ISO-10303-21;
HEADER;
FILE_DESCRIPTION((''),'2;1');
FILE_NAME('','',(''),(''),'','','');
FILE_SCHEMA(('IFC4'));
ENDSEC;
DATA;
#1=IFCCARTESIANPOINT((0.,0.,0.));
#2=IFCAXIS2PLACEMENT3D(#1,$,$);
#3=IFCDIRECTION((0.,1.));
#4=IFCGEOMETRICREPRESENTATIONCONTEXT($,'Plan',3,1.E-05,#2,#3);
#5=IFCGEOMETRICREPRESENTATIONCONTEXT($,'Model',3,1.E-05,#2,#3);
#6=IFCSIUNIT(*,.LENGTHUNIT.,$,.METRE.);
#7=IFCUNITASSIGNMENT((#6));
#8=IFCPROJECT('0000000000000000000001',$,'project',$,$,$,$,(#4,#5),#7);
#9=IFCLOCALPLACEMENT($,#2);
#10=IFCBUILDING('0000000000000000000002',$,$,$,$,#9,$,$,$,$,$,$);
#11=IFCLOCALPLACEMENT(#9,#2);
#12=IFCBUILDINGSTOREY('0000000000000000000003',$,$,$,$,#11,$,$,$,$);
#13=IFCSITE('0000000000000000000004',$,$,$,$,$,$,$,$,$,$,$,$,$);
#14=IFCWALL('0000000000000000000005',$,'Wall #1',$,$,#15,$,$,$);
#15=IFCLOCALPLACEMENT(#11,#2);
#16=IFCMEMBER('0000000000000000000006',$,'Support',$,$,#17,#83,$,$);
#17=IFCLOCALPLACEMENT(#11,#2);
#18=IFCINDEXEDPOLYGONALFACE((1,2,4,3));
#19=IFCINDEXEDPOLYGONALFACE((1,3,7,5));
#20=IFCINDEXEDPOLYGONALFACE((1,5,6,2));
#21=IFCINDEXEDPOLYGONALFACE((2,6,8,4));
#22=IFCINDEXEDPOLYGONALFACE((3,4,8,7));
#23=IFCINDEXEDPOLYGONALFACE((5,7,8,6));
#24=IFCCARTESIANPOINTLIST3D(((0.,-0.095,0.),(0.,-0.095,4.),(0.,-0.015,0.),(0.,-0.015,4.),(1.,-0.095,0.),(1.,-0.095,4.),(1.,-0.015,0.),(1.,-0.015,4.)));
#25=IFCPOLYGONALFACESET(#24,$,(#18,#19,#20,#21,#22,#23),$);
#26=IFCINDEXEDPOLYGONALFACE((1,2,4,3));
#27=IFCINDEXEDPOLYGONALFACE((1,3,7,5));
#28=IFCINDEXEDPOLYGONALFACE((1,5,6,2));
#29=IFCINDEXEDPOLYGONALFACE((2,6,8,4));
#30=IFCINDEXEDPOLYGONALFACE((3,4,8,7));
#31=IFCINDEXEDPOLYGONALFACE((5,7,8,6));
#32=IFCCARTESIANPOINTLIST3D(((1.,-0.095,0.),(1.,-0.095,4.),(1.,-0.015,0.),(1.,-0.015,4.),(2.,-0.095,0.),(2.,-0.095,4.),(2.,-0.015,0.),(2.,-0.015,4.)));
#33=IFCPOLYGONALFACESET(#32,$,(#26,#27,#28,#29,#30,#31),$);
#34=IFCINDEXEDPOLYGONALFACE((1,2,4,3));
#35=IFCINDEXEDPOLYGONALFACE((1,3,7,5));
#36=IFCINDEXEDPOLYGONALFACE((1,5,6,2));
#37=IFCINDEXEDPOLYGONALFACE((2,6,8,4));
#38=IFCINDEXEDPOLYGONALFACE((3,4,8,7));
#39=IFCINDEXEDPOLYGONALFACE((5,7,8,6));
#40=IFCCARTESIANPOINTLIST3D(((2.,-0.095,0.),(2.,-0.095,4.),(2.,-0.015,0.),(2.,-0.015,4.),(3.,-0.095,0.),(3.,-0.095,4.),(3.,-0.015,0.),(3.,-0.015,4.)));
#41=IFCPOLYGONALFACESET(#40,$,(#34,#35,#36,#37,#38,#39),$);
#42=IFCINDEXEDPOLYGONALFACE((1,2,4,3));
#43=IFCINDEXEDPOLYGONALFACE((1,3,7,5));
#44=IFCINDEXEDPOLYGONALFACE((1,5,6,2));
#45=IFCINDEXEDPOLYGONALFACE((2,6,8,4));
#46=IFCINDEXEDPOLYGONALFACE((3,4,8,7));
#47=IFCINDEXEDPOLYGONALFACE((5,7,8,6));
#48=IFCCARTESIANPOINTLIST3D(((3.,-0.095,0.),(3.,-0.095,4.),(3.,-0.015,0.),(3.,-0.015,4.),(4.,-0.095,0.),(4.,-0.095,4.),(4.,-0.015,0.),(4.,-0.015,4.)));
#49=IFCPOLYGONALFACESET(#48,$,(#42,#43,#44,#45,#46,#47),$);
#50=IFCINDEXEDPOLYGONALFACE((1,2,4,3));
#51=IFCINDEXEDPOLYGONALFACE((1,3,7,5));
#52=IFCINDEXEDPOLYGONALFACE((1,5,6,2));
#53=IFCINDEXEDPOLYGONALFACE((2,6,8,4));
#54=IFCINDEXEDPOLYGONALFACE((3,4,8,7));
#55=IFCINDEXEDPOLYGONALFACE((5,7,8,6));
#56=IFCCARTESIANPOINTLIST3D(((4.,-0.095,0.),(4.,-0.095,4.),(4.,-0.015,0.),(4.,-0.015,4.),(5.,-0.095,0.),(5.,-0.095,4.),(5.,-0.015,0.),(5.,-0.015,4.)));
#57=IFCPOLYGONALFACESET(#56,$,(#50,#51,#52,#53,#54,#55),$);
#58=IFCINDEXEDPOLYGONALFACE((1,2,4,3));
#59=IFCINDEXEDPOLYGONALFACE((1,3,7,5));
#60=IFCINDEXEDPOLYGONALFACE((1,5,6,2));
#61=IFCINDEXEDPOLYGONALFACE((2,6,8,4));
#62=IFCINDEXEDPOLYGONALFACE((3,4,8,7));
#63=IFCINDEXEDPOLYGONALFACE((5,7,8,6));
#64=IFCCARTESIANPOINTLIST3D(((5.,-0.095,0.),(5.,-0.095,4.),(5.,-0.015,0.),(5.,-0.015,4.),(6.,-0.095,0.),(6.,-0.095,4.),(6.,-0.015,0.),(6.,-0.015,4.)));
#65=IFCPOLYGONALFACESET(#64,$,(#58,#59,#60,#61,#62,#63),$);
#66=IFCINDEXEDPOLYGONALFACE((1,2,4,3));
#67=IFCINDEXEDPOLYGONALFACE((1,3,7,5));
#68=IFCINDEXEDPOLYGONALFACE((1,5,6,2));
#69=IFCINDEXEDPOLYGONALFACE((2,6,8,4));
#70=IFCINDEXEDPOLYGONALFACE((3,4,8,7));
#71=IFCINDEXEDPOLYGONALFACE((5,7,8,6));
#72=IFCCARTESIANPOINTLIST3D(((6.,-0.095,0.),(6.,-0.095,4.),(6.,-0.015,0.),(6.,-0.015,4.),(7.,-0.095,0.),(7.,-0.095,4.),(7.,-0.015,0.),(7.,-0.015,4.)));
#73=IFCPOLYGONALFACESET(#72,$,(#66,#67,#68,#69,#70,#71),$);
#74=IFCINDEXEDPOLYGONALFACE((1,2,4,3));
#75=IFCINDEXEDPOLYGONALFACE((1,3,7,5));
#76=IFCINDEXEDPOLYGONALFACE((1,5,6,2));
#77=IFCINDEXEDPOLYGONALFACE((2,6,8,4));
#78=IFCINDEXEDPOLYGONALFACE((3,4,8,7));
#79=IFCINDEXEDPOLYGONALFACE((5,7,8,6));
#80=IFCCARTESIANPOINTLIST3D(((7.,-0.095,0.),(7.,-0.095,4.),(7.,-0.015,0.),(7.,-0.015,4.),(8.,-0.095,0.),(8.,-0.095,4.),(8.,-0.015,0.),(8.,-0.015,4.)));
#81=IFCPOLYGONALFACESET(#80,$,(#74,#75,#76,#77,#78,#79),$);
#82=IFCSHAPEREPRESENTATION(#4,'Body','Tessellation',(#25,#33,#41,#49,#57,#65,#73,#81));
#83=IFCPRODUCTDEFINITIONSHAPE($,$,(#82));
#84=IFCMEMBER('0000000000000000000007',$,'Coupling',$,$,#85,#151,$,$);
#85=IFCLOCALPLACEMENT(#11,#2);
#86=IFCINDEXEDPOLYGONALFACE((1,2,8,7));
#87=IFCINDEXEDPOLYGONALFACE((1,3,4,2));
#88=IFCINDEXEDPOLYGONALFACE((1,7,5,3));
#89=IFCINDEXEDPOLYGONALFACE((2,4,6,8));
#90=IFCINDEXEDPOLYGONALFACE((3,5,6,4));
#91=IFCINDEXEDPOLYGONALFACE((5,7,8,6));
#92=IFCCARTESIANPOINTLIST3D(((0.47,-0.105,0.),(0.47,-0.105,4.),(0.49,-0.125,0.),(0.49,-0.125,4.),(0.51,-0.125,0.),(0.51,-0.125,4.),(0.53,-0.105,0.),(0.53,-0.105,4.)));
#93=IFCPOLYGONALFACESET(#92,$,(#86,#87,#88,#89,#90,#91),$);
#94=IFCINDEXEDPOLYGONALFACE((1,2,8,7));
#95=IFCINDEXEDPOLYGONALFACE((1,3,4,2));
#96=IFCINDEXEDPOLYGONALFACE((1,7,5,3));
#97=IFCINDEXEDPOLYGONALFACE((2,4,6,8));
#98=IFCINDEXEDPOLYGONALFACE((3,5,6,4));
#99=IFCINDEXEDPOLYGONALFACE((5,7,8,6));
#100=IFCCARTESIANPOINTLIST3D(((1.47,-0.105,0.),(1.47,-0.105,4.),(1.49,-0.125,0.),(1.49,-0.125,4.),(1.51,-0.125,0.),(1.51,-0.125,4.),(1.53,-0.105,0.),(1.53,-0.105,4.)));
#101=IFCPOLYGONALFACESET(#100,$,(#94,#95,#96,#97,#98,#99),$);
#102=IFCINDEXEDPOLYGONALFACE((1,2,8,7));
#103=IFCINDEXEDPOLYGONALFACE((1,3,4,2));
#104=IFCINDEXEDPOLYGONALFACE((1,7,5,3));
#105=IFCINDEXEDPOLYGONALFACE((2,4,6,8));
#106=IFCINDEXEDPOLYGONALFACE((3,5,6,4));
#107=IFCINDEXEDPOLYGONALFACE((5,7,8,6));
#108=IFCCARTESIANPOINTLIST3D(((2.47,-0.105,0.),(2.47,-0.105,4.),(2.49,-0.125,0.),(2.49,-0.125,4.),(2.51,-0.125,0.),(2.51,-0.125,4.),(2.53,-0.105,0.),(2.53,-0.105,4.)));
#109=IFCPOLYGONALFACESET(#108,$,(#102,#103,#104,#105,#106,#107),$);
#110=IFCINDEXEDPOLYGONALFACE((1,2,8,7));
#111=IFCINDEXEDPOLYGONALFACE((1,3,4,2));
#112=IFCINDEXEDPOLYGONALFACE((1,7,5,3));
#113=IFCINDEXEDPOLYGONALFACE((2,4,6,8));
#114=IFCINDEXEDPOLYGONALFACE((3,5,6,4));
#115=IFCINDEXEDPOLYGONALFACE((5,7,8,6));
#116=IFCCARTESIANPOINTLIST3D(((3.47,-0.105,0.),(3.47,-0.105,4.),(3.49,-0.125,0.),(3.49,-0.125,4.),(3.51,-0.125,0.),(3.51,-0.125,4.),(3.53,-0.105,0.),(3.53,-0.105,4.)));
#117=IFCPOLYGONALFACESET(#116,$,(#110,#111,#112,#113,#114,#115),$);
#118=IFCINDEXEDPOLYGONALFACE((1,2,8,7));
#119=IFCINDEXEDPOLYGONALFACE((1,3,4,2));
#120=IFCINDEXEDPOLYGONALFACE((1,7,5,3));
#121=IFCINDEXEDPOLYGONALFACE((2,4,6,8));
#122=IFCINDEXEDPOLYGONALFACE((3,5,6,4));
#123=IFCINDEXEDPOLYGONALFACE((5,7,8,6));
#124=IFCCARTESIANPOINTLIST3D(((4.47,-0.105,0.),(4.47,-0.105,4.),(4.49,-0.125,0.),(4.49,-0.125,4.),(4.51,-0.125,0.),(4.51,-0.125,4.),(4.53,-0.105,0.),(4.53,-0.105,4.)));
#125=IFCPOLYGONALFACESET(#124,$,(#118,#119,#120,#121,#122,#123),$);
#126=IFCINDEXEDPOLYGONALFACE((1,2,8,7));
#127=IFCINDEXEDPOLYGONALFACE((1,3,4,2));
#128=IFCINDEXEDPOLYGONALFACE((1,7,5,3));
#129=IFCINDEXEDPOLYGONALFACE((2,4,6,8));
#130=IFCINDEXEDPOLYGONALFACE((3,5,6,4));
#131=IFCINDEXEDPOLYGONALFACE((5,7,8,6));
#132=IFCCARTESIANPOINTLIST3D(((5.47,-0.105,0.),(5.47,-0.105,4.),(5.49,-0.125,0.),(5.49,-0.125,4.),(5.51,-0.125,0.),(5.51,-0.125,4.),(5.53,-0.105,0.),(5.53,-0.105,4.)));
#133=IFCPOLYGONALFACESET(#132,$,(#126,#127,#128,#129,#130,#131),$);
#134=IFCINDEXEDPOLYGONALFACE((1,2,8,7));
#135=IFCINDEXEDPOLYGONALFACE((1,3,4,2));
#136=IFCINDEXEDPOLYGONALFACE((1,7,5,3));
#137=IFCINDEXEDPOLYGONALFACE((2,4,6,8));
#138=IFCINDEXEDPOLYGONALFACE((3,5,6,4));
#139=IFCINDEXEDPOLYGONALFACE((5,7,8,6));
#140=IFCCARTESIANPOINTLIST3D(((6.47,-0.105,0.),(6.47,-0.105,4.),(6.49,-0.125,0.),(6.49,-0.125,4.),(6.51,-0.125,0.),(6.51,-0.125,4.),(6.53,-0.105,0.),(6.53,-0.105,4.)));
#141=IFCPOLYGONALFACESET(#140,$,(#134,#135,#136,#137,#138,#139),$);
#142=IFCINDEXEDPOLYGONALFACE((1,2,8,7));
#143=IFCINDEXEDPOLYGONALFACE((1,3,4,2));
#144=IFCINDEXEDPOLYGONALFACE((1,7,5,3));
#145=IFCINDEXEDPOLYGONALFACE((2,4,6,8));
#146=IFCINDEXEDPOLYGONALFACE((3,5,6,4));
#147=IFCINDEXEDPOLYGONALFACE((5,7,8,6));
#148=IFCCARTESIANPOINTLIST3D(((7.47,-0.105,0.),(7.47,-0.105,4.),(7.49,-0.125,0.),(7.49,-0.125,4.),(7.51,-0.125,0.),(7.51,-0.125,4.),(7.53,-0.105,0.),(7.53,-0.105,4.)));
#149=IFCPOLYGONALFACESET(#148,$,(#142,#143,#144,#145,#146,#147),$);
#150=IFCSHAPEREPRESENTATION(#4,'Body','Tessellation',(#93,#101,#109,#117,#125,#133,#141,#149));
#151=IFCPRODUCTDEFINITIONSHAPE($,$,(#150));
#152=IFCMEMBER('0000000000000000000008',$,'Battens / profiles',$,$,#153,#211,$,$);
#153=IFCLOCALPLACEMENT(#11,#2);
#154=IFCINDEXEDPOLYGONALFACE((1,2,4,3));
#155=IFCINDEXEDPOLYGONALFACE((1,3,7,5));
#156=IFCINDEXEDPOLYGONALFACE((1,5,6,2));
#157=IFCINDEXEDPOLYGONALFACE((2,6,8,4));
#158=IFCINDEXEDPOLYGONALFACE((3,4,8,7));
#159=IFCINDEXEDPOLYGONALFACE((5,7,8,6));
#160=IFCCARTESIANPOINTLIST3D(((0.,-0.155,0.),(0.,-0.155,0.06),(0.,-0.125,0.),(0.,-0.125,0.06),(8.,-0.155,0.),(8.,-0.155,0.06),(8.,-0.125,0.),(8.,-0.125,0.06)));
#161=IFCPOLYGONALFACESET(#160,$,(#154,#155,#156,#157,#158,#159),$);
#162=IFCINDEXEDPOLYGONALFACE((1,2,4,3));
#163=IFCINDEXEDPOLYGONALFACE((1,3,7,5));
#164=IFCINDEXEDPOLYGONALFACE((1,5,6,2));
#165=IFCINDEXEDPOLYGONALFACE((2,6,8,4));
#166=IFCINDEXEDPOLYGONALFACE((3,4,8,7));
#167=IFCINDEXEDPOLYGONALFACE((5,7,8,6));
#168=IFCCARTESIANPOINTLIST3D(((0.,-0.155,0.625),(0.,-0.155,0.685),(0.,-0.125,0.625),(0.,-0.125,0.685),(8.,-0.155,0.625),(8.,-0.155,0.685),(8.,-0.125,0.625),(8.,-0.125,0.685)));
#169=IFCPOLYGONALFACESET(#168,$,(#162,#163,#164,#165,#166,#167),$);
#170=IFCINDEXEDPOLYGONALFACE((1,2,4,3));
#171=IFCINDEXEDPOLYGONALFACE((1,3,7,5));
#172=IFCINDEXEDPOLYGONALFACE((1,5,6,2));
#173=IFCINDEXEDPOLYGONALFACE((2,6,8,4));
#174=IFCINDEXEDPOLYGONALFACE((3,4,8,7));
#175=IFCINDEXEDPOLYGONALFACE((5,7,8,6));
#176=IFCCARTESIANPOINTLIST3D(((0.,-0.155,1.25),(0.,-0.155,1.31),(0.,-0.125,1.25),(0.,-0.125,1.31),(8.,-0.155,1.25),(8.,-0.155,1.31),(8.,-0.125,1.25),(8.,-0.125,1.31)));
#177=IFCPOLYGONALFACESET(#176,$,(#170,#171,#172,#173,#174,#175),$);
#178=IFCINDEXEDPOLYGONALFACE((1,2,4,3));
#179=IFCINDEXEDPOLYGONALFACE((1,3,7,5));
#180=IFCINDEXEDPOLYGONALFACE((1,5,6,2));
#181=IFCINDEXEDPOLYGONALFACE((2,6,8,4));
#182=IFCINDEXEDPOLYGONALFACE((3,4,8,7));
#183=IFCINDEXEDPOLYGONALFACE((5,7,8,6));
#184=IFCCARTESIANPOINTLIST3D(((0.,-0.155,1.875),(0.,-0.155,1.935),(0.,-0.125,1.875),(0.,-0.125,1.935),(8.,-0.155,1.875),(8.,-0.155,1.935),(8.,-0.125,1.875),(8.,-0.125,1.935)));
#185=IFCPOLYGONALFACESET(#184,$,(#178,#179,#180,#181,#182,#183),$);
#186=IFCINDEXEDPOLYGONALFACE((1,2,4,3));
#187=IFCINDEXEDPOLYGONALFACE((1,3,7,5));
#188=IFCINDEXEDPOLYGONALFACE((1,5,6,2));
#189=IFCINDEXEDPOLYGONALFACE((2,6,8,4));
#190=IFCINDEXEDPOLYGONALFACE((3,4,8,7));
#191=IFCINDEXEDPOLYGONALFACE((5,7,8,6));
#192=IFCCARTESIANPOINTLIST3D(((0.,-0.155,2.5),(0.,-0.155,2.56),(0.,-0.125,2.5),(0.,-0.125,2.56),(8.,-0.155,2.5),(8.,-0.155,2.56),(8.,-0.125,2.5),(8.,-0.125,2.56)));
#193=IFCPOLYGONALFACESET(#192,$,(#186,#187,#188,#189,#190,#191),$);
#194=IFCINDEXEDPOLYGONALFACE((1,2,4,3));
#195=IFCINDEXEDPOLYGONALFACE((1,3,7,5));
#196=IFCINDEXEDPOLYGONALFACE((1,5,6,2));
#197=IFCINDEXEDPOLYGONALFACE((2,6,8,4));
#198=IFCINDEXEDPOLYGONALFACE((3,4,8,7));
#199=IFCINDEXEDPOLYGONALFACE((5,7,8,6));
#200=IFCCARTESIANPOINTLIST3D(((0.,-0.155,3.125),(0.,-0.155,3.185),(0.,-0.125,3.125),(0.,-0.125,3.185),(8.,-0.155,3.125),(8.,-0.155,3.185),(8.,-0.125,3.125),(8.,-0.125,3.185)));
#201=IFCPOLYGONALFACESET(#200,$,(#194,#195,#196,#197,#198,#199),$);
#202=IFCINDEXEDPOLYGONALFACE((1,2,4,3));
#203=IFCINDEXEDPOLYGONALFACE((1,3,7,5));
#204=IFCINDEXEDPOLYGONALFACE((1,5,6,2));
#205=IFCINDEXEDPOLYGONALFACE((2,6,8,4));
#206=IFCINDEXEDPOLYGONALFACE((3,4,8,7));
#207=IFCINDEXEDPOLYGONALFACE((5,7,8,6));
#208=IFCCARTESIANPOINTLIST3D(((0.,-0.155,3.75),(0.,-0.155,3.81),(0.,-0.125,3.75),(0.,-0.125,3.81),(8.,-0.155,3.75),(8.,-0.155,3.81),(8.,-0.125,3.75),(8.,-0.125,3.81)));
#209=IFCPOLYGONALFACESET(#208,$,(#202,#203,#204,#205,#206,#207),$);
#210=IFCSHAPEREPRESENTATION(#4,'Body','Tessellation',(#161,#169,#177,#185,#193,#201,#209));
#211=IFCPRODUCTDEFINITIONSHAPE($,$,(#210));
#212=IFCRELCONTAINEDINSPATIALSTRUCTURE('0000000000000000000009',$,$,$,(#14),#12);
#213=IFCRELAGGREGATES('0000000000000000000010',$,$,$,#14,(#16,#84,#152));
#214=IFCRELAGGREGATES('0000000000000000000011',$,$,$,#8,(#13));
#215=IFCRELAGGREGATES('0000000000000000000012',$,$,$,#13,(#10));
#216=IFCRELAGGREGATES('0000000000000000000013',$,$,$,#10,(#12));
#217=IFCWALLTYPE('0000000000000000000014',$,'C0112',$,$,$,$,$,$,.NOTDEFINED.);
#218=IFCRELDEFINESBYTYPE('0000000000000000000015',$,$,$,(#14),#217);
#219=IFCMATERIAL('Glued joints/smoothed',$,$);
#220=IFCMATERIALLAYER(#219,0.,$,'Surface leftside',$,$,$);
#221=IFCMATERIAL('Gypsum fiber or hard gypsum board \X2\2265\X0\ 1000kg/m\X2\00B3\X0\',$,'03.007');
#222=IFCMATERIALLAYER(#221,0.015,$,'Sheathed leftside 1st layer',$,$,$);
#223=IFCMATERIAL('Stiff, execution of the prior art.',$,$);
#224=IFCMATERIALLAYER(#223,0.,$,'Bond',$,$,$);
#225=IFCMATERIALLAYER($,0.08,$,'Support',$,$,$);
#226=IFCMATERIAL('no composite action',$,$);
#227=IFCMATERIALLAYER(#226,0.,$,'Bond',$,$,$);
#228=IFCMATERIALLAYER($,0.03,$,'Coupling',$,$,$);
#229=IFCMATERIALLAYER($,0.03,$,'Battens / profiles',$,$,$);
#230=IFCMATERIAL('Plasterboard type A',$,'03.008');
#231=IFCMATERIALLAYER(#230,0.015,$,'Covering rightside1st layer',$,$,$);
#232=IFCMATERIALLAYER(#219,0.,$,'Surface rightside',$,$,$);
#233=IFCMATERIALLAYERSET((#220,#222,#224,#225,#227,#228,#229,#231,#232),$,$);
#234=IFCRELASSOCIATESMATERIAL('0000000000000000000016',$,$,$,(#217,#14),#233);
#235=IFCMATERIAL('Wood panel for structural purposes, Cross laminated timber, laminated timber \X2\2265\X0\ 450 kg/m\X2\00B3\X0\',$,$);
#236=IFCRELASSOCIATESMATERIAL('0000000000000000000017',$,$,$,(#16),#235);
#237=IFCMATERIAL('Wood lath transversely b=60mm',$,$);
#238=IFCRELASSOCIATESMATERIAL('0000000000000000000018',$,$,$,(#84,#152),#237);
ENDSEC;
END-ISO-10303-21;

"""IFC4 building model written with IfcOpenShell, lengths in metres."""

from ifc_helpers import new_model, si_unit, direction, frame, frame_2d, origin, place, context, project, spatial, polyline, rectangle, outline, extrude, material, layer, layer_set, type_object, element, aggregate, save


model = new_model("IFC4")

# Units and contexts
plan_context = context("Plan", 3, precision=1e-05, world=origin(), true_north=direction((0.0, 1.0)))
model_context = context("Model", 3, precision=1e-05, world=origin(), true_north=direction((0.0, 1.0)))
ifc_project = project(units=[si_unit("LENGTHUNIT", "METRE")], contexts=[plan_context, model_context])

# Site, building, storey
site = spatial("IfcSite", under=ifc_project)
building_placement = place(None, origin())
building = spatial("IfcBuilding", under=site, at=building_placement)
storey_placement = place(building_placement, origin())
storey = spatial("IfcBuildingStorey", under=building, at=storey_placement)

# Wall, members
ifc_material_1 = material(Name="Glued joints/smoothed")
ifc_layer_1 = layer(ifc_material_1, 0.0, Name="Surface leftside")
ifc_material_2 = material(Name="Gypsum fiber or hard gypsum board ≥ 1000kg/m³", Category="03.007")
ifc_layer_2 = layer(ifc_material_2, 0.015, Name="Sheathed leftside 1st layer")
ifc_material_3 = material(Name="Stiff, execution of the prior art.")
ifc_layer_3 = layer(ifc_material_3, 0.0, Name="Bond")
ifc_layer_4 = layer(None, 0.08, Name="Support")
ifc_material_4 = material(Name="no composite action")
ifc_layer_5 = layer(ifc_material_4, 0.0, Name="Bond")
ifc_layer_6 = layer(None, 0.03, Name="Coupling")
ifc_layer_7 = layer(None, 0.03, Name="Battens / profiles")
ifc_material_5 = material(Name="Plasterboard type A", Category="03.008")
ifc_layer_8 = layer(ifc_material_5, 0.015, Name="Covering rightside1st layer")
ifc_layer_9 = layer(ifc_material_1, 0.0, Name="Surface rightside")
ifc_layer_set = layer_set([ifc_layer_1, ifc_layer_2, ifc_layer_3, ifc_layer_4, ifc_layer_5, ifc_layer_6, ifc_layer_7, ifc_layer_8, ifc_layer_9])
wall_type = type_object("IfcWallType", Name="C0112", PredefinedType="NOTDEFINED", material=ifc_layer_set)
wall_placement = place(None, frame((0.0, 0.0, 0.0), z_axis=(0.0, -1.0, 0.0), x_axis=(1.0, 0.0, 0.0)))
wall = element("IfcWall", 1, at=wall_placement, inside=storey, type_object=wall_type, material=ifc_layer_set, Name="Wall #1")
ifc_material_6 = material(Name="Wood panel for structural purposes, Cross laminated timber, laminated timber ≥ 450 kg/m³")
member_1_placement = place(wall_placement, origin())
member_1 = element("IfcMember", 2, at=member_1_placement, material=ifc_material_6, Name="Support", context=plan_context, shape_type="SweptSolid", body=[
    extrude(rectangle(XDim=1.0, YDim=0.08, at=frame_2d((0.5, 0.04), x_axis=(1.0, 0.0))), frame((0.0, 4.0, 0.015), z_axis=(0.0, -1.0, 0.0), x_axis=(1.0, 0.0, 0.0)), (0.0, 0.0, 1.0), 4.0),
    extrude(rectangle(XDim=1.0, YDim=0.08, at=frame_2d((0.5, 0.04), x_axis=(1.0, 0.0))), frame((1.0, 4.0, 0.015), z_axis=(0.0, -1.0, 0.0), x_axis=(1.0, 0.0, 0.0)), (0.0, 0.0, 1.0), 4.0),
    extrude(rectangle(XDim=1.0, YDim=0.08, at=frame_2d((0.5, 0.04), x_axis=(1.0, 0.0))), frame((2.0, 4.0, 0.015), z_axis=(0.0, -1.0, 0.0), x_axis=(1.0, 0.0, 0.0)), (0.0, 0.0, 1.0), 4.0),
    extrude(rectangle(XDim=1.0, YDim=0.08, at=frame_2d((0.5, 0.04), x_axis=(1.0, 0.0))), frame((3.0, 4.0, 0.015), z_axis=(0.0, -1.0, 0.0), x_axis=(1.0, 0.0, 0.0)), (0.0, 0.0, 1.0), 4.0),
    extrude(rectangle(XDim=1.0, YDim=0.08, at=frame_2d((0.5, 0.04), x_axis=(1.0, 0.0))), frame((4.0, 4.0, 0.015), z_axis=(0.0, -1.0, 0.0), x_axis=(1.0, 0.0, 0.0)), (0.0, 0.0, 1.0), 4.0),
    extrude(rectangle(XDim=1.0, YDim=0.08, at=frame_2d((0.5, 0.04), x_axis=(1.0, 0.0))), frame((5.0, 4.0, 0.015), z_axis=(0.0, -1.0, 0.0), x_axis=(1.0, 0.0, 0.0)), (0.0, 0.0, 1.0), 4.0),
    extrude(rectangle(XDim=1.0, YDim=0.08, at=frame_2d((0.5, 0.04), x_axis=(1.0, 0.0))), frame((6.0, 4.0, 0.015), z_axis=(0.0, -1.0, 0.0), x_axis=(1.0, 0.0, 0.0)), (0.0, 0.0, 1.0), 4.0),
    extrude(rectangle(XDim=1.0, YDim=0.08, at=frame_2d((0.5, 0.04), x_axis=(1.0, 0.0))), frame((7.0, 4.0, 0.015), z_axis=(0.0, -1.0, 0.0), x_axis=(1.0, 0.0, 0.0)), (0.0, 0.0, 1.0), 4.0),
])
ifc_material_7 = material(Name="Wood lath transversely b=60mm")
member_2_placement = place(wall_placement, origin())
member_2 = element("IfcMember", 3, at=member_2_placement, material=ifc_material_7, Name="Coupling", context=plan_context, shape_type="SweptSolid", body=[
    extrude(outline(polyline([(0.0, 0.0), (0.06, 0.0), (0.04, 0.02), (0.02, 0.02), (0.0, 0.0)])), frame((0.47, 4.0, 0.105), z_axis=(0.0, -1.0, 0.0), x_axis=(1.0, 0.0, 0.0)), (0.0, 0.0, 1.0), 4.0),
    extrude(outline(polyline([(0.0, 0.0), (0.06, 0.0), (0.04, 0.02), (0.02, 0.02), (0.0, 0.0)])), frame((1.47, 4.0, 0.105), z_axis=(0.0, -1.0, 0.0), x_axis=(1.0, 0.0, 0.0)), (0.0, 0.0, 1.0), 4.0),
    extrude(outline(polyline([(0.0, 0.0), (0.06, 0.0), (0.04, 0.02), (0.02, 0.02), (0.0, 0.0)])), frame((2.47, 4.0, 0.105), z_axis=(0.0, -1.0, 0.0), x_axis=(1.0, 0.0, 0.0)), (0.0, 0.0, 1.0), 4.0),
    extrude(outline(polyline([(0.0, 0.0), (0.06, 0.0), (0.04, 0.02), (0.02, 0.02), (0.0, 0.0)])), frame((3.47, 4.0, 0.105), z_axis=(0.0, -1.0, 0.0), x_axis=(1.0, 0.0, 0.0)), (0.0, 0.0, 1.0), 4.0),
    extrude(outline(polyline([(0.0, 0.0), (0.06, 0.0), (0.04, 0.02), (0.02, 0.02), (0.0, 0.0)])), frame((4.47, 4.0, 0.105), z_axis=(0.0, -1.0, 0.0), x_axis=(1.0, 0.0, 0.0)), (0.0, 0.0, 1.0), 4.0),
    extrude(outline(polyline([(0.0, 0.0), (0.06, 0.0), (0.04, 0.02), (0.02, 0.02), (0.0, 0.0)])), frame((5.47, 4.0, 0.105), z_axis=(0.0, -1.0, 0.0), x_axis=(1.0, 0.0, 0.0)), (0.0, 0.0, 1.0), 4.0),
    extrude(outline(polyline([(0.0, 0.0), (0.06, 0.0), (0.04, 0.02), (0.02, 0.02), (0.0, 0.0)])), frame((6.47, 4.0, 0.105), z_axis=(0.0, -1.0, 0.0), x_axis=(1.0, 0.0, 0.0)), (0.0, 0.0, 1.0), 4.0),
    extrude(outline(polyline([(0.0, 0.0), (0.06, 0.0), (0.04, 0.02), (0.02, 0.02), (0.0, 0.0)])), frame((7.47, 4.0, 0.105), z_axis=(0.0, -1.0, 0.0), x_axis=(1.0, 0.0, 0.0)), (0.0, 0.0, 1.0), 4.0),
])
member_3_placement = place(wall_placement, origin())
member_3 = element("IfcMember", 4, at=member_3_placement, material=ifc_material_7, Name="Battens / profiles", context=plan_context, shape_type="SweptSolid", body=[
    extrude(rectangle(XDim=0.06, YDim=0.03, at=frame_2d((0.03, 0.015), x_axis=(1.0, 0.0))), frame((0.0, 0.0, 0.125), z_axis=(1.0, 0.0, 0.0), x_axis=(0.0, 1.0, 0.0)), (0.0, 0.0, 1.0), 8.0),
    extrude(rectangle(XDim=0.06, YDim=0.03, at=frame_2d((0.03, 0.015), x_axis=(1.0, 0.0))), frame((0.0, 0.625, 0.125), z_axis=(1.0, 0.0, 0.0), x_axis=(0.0, 1.0, 0.0)), (0.0, 0.0, 1.0), 8.0),
    extrude(rectangle(XDim=0.06, YDim=0.03, at=frame_2d((0.03, 0.015), x_axis=(1.0, 0.0))), frame((0.0, 1.25, 0.125), z_axis=(1.0, 0.0, 0.0), x_axis=(0.0, 1.0, 0.0)), (0.0, 0.0, 1.0), 8.0),
    extrude(rectangle(XDim=0.06, YDim=0.03, at=frame_2d((0.03, 0.015), x_axis=(1.0, 0.0))), frame((0.0, 1.875, 0.125), z_axis=(1.0, 0.0, 0.0), x_axis=(0.0, 1.0, 0.0)), (0.0, 0.0, 1.0), 8.0),
    extrude(rectangle(XDim=0.06, YDim=0.03, at=frame_2d((0.03, 0.015), x_axis=(1.0, 0.0))), frame((0.0, 2.5, 0.125), z_axis=(1.0, 0.0, 0.0), x_axis=(0.0, 1.0, 0.0)), (0.0, 0.0, 1.0), 8.0),
    extrude(rectangle(XDim=0.06, YDim=0.03, at=frame_2d((0.03, 0.015), x_axis=(1.0, 0.0))), frame((0.0, 3.125, 0.125), z_axis=(1.0, 0.0, 0.0), x_axis=(0.0, 1.0, 0.0)), (0.0, 0.0, 1.0), 8.0),
    extrude(rectangle(XDim=0.06, YDim=0.03, at=frame_2d((0.03, 0.015), x_axis=(1.0, 0.0))), frame((0.0, 3.75, 0.125), z_axis=(1.0, 0.0, 0.0), x_axis=(0.0, 1.0, 0.0)), (0.0, 0.0, 1.0), 8.0),
])
aggregate(wall, [member_1, member_2, member_3])

save(model, "model.ifc")
